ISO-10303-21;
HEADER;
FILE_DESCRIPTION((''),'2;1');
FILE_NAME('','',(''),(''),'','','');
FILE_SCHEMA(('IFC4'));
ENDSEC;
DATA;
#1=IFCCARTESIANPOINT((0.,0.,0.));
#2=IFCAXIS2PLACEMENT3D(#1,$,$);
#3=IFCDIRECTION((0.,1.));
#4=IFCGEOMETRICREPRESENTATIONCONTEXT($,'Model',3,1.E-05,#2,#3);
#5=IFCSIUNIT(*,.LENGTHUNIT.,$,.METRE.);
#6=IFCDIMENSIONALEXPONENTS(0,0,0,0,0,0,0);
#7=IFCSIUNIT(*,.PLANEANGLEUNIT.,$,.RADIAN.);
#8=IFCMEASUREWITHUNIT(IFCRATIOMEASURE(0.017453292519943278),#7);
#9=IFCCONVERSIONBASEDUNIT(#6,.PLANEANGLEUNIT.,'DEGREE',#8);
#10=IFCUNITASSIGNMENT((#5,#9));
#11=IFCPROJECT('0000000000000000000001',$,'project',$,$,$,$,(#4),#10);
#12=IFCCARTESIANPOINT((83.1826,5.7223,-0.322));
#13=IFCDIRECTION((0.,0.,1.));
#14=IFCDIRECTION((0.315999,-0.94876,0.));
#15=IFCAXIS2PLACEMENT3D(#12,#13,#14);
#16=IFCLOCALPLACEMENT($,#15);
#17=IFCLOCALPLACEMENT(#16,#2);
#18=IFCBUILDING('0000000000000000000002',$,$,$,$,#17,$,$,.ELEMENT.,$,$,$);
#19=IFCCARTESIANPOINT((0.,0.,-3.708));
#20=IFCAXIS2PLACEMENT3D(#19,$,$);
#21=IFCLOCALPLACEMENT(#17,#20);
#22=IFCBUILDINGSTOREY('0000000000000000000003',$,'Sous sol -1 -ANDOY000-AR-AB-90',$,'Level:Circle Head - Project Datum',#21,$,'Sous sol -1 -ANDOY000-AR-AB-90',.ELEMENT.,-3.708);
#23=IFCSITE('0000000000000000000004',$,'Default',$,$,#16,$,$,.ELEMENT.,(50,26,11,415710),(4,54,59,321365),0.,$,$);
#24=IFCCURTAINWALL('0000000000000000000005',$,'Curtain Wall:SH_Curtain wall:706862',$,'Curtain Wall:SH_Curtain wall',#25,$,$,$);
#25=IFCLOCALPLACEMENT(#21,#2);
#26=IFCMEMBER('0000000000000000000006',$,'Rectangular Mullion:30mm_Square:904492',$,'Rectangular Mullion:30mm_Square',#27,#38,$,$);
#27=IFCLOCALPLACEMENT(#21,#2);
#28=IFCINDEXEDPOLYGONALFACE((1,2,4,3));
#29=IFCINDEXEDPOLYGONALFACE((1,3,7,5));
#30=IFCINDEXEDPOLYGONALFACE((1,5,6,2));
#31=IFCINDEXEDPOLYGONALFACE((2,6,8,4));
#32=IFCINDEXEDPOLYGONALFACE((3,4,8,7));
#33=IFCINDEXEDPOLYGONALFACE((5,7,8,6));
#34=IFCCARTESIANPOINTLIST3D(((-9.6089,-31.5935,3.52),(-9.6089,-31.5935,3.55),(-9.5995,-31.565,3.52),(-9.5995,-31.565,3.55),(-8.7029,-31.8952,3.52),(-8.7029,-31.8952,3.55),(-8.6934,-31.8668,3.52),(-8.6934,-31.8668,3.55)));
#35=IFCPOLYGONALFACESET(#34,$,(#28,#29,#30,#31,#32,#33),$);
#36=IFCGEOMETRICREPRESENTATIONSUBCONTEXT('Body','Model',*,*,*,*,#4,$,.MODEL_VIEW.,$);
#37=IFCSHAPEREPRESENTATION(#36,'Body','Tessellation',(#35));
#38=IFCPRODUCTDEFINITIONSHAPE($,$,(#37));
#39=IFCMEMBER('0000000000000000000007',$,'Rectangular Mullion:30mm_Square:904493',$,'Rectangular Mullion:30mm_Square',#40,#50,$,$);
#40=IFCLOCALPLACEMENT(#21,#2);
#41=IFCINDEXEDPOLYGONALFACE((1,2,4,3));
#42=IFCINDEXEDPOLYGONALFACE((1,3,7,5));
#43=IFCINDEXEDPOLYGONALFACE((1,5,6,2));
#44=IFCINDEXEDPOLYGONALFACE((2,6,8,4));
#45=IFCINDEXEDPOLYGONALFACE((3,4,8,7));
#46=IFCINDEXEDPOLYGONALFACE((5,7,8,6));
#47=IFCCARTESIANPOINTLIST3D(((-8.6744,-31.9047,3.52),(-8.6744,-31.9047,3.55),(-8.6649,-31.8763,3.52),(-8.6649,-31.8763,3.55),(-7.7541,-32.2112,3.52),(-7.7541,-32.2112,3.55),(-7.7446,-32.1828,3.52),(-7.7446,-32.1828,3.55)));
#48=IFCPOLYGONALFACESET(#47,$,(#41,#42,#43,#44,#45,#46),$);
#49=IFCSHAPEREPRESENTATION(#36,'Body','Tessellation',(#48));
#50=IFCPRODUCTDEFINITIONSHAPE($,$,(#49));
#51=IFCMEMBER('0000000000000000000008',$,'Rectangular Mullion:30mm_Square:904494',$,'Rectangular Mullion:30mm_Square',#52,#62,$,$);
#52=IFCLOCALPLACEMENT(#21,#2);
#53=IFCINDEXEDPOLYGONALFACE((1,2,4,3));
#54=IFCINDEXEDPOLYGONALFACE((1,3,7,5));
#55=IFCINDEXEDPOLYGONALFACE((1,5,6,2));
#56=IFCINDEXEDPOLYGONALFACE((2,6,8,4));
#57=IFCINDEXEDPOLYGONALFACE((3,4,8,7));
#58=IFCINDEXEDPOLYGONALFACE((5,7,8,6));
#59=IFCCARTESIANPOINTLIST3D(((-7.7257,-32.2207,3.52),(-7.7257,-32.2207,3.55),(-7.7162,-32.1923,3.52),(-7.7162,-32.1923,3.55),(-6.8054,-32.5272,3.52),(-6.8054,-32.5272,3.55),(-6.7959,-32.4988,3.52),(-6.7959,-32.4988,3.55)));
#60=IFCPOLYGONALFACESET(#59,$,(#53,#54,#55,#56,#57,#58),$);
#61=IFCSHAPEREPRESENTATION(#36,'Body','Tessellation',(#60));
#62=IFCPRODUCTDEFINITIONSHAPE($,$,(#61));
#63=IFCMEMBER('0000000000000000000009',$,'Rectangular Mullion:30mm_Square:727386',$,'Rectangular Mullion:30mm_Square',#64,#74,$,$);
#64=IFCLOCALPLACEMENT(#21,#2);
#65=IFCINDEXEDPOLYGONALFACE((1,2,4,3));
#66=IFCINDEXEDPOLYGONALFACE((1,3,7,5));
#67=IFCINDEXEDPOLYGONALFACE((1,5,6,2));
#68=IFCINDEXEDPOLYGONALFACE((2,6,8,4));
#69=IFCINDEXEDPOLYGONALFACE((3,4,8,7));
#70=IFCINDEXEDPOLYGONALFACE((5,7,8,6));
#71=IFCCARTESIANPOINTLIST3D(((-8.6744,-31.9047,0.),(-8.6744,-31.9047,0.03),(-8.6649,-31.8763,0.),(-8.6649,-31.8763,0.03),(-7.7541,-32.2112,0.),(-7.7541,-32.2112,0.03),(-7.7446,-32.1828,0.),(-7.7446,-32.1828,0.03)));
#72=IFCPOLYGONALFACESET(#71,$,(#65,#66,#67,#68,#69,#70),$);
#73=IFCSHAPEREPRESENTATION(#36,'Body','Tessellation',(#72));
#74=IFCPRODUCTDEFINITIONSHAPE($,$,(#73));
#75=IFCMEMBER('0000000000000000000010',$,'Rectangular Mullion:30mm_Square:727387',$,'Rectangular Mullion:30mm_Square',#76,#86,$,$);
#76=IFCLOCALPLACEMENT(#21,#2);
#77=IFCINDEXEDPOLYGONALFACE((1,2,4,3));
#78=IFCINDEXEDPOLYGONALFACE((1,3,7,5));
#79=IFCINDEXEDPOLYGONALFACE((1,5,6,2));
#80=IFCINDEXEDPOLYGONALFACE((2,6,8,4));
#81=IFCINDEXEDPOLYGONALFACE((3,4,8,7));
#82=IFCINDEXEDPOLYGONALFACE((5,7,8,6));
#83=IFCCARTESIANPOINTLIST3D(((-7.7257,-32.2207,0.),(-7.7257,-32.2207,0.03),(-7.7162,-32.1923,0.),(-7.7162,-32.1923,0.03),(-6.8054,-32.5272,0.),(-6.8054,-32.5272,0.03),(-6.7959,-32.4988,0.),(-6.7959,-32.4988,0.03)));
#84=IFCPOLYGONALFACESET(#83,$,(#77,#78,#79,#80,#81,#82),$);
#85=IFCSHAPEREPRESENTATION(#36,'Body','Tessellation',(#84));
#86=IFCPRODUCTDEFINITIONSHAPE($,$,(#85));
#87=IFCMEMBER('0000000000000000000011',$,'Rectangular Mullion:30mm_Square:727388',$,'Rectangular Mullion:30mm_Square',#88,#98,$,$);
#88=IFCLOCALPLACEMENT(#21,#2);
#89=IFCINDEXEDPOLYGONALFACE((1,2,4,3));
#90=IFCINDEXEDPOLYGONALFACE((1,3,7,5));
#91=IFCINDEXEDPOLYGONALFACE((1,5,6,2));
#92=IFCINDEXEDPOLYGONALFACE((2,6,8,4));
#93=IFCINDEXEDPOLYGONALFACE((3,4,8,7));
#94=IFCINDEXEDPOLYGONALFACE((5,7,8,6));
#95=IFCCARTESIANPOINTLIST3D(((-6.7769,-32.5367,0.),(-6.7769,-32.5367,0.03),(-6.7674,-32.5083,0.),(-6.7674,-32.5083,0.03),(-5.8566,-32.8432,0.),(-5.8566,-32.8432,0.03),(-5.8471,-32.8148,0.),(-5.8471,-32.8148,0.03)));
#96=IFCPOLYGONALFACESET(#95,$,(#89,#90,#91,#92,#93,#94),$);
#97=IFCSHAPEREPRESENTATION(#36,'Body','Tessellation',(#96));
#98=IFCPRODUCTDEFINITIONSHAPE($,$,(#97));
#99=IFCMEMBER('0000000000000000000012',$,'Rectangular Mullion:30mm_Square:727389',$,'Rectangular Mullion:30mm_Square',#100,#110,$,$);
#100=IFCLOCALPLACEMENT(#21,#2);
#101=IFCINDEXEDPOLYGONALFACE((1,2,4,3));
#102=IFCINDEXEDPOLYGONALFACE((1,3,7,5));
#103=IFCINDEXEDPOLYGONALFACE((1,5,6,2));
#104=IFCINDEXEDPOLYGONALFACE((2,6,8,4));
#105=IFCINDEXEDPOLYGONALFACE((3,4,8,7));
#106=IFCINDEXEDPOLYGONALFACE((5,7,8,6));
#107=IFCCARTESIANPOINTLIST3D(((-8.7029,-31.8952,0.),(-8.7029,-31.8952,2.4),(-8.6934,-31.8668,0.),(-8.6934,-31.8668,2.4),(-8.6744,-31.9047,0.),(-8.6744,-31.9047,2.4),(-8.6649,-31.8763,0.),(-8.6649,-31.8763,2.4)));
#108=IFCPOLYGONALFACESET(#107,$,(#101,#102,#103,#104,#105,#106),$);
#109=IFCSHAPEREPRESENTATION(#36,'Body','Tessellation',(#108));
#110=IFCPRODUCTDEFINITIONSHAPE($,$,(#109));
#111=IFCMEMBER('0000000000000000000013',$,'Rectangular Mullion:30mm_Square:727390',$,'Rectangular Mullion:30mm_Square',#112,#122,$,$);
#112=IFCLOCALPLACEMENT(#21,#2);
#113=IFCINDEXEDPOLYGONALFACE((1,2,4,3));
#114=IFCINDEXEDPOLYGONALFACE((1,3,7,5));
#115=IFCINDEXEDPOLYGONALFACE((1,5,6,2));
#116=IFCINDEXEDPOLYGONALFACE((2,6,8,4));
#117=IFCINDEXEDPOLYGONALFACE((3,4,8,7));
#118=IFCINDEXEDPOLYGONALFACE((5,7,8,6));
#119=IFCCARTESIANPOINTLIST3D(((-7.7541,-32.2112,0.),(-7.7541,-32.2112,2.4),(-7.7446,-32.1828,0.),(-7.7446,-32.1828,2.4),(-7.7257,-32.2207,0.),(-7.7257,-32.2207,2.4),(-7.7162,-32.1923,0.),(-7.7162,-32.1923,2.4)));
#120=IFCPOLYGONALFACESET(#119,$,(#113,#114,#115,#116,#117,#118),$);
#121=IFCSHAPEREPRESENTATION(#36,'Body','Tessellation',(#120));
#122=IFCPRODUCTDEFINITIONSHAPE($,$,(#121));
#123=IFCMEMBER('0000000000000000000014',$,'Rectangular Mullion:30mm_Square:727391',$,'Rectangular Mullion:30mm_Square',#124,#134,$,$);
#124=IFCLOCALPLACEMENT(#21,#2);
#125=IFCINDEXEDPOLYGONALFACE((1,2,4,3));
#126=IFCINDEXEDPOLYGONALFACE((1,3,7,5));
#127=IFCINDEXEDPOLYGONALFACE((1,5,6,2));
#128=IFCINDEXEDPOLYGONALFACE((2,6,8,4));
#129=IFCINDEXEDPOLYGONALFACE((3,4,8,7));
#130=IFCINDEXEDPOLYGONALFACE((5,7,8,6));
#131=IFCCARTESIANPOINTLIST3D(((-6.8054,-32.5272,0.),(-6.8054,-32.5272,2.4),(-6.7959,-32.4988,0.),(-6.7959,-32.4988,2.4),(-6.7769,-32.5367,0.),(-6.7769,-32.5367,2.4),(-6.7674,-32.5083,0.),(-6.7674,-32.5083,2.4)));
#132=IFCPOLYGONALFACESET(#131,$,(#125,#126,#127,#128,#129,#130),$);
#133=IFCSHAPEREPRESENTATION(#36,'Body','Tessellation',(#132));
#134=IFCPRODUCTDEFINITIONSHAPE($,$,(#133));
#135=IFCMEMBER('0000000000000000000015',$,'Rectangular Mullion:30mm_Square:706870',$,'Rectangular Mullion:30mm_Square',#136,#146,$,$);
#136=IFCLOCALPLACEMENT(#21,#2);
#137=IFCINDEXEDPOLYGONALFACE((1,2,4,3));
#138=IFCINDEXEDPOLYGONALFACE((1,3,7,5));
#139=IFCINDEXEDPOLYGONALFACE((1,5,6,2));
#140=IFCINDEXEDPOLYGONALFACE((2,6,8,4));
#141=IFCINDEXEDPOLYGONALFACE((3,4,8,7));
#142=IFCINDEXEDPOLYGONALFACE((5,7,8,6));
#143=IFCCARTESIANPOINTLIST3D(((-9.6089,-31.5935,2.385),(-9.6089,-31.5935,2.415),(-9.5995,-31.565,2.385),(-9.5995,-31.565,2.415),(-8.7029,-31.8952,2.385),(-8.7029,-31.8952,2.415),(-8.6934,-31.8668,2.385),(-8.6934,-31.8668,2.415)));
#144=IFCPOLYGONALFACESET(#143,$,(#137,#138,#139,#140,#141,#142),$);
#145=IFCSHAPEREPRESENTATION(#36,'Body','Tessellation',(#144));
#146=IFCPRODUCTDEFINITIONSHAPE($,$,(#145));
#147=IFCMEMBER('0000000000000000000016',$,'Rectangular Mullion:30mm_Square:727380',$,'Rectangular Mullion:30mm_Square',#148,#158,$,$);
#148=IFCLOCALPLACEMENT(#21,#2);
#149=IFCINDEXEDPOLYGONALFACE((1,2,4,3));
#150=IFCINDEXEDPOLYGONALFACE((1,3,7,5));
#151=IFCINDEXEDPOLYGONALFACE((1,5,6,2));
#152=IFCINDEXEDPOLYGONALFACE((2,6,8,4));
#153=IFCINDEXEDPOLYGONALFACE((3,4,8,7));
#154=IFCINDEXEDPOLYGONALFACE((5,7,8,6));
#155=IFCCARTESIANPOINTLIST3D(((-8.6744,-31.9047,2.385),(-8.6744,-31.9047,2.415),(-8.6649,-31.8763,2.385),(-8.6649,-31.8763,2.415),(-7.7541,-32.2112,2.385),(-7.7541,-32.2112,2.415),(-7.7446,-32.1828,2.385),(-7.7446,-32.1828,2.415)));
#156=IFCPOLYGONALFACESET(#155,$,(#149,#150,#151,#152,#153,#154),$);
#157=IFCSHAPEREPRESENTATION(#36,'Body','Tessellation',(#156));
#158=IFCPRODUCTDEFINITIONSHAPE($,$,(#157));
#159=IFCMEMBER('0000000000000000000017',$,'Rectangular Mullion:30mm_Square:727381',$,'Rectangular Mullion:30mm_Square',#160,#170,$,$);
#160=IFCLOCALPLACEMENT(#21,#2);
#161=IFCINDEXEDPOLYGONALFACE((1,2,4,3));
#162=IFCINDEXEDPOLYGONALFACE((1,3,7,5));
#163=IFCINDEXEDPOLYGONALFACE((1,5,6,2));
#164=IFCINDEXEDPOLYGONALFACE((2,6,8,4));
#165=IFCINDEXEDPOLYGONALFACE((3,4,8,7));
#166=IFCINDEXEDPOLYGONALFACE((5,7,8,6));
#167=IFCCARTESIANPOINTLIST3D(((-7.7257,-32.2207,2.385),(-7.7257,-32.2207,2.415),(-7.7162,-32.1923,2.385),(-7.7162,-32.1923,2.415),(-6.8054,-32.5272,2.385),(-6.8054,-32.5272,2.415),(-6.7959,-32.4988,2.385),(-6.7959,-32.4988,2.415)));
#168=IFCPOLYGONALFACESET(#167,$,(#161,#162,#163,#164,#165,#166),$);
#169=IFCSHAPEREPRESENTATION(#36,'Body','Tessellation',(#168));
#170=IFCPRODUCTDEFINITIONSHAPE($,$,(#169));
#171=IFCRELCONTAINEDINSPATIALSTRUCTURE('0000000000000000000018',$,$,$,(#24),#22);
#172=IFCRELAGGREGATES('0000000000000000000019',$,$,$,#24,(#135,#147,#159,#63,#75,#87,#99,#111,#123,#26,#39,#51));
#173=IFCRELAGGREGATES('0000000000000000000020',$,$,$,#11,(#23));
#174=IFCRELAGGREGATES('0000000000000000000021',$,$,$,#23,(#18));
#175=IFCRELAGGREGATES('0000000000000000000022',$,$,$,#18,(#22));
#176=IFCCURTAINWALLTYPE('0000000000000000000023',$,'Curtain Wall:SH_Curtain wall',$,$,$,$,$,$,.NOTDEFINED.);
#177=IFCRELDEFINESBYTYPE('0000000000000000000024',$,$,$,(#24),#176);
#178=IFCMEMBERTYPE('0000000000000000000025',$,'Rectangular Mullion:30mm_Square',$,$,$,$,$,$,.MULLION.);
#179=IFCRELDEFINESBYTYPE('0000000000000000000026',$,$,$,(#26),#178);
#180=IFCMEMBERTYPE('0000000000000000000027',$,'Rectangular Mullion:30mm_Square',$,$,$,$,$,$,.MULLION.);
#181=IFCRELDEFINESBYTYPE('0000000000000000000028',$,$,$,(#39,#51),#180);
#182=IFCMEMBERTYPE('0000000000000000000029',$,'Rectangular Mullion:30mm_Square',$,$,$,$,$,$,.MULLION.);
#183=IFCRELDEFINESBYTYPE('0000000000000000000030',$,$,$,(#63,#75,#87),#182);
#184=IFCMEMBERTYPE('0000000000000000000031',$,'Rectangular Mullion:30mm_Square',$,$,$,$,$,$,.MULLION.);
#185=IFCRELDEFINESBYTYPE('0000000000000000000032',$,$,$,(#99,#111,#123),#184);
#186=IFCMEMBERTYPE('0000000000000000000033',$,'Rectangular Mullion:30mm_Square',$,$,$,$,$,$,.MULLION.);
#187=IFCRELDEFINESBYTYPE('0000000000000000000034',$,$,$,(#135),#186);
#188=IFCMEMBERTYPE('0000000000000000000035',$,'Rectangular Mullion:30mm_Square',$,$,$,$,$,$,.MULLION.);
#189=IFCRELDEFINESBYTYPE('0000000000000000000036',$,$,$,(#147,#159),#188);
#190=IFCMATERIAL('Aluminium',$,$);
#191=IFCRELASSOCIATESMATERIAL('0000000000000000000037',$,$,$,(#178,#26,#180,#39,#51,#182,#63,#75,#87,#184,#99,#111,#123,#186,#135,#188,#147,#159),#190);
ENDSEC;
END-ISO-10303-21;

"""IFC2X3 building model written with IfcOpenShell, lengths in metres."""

from ifc_helpers import new_model, entity, si_unit, converted_unit, direction, frame, origin, origin_2d_with_axis, place, context, subcontext, project, spatial, rectangle, extrude, source, transform, mapped, material, type_object, type_shapes, element, aggregate, save


model = new_model("IFC2X3")

# Units and contexts
model_context = context("Model", 3, precision=1e-05, world=origin(), true_north=direction((0.0, 1.0)))
body_context = subcontext(model_context, "Body", "Model", "MODEL_VIEW")
ifc_project = project(units=[si_unit("LENGTHUNIT", "METRE"), converted_unit("PLANEANGLEUNIT", "DEGREE", entity("IfcRatioMeasure", 0.017453292519943278), si_unit("PLANEANGLEUNIT", "RADIAN"), dimensions=[0, 0, 0, 0, 0, 0, 0])], contexts=[model_context])

# Site, building, storey
site_placement = place(None, frame((83.1826, 5.7223, -0.322), z_axis=(0.0, 0.0, 1.0), x_axis=(0.315999, -0.94876, 0.0)))
site = spatial("IfcSite", under=ifc_project, at=site_placement, Name="Default", CompositionType="ELEMENT", RefLatitude=(50, 26, 11, 415710), RefLongitude=(4, 54, 59, 321365), RefElevation=0.0)
building_placement = place(site_placement, origin())
building = spatial("IfcBuilding", under=site, at=building_placement, CompositionType="ELEMENT")
storey_placement = place(building_placement, frame((0.0, 0.0, -3.708)))
storey = spatial("IfcBuildingStorey", under=building, at=storey_placement, Name="Sous sol -1 -ANDOY000-AR-AB-90", ObjectType="Level:Circle Head - Project Datum", LongName="Sous sol -1 -ANDOY000-AR-AB-90", CompositionType="ELEMENT", Elevation=-3.708)

# Curtain wall, members
curtain_wall_type = type_object("IfcCurtainWallType", Name="Curtain Wall:SH_Curtain wall", PredefinedType="NOTDEFINED")
curtain_wall_1_placement = place(storey_placement, frame((0.0, 0.0, 3.708)))
curtain_wall_1 = element("IfcCurtainWall", 1, at=curtain_wall_1_placement, inside=storey, type_object=curtain_wall_type, Name="Curtain Wall:SH_Curtain wall:706862", ObjectType="Curtain Wall:SH_Curtain wall")
ifc_material_1 = material(Name="Aluminium")
member_type_1 = type_object("IfcMemberType", Name="Rectangular Mullion:30mm_Square", PredefinedType="MULLION", material=ifc_material_1)
shared_shape_1 = source(origin(), body_context, "Body", "SweptSolid", [
    extrude(rectangle(XDim=0.03, YDim=0.03, at=origin_2d_with_axis()), frame((-0.015, 0.0, -0.955), z_axis=(0.0, 0.0, 1.0), x_axis=(0.0, -1.0, 0.0)), (0.0, 0.0, 1.0), 0.955),
])
type_shapes(member_type_1, [shared_shape_1])
member_1_placement = place(curtain_wall_1_placement, frame((-8.6981, -31.881, -0.158), z_axis=(0.948759, -0.316, 0.0), x_axis=(0.0, 0.0, 1.0)))
member_1 = element("IfcMember", 2, at=member_1_placement, type_object=member_type_1, material=ifc_material_1, Name="Rectangular Mullion:30mm_Square:904492", ObjectType="Rectangular Mullion:30mm_Square", context=body_context, shape_type="MappedRepresentation", body=[
    mapped(shared_shape_1, transform((0.0, 0.0, 0.0), scale=1.0)),
])
member_type_2 = type_object("IfcMemberType", Name="Rectangular Mullion:30mm_Square", PredefinedType="MULLION", material=ifc_material_1)
shared_shape_2 = source(origin(), body_context, "Body", "SweptSolid", [
    extrude(rectangle(XDim=0.03, YDim=0.03, at=origin_2d_with_axis()), frame((-0.015, 0.0, -0.97), z_axis=(0.0, 0.0, 1.0), x_axis=(0.0, -1.0, 0.0)), (0.0, 0.0, 1.0), 0.97),
])
type_shapes(member_type_2, [shared_shape_2])
member_2_placement = place(curtain_wall_1_placement, frame((-7.7494, -32.197, -0.158), z_axis=(0.948759, -0.316, 0.0), x_axis=(0.0, 0.0, 1.0)))
member_2 = element("IfcMember", 3, at=member_2_placement, type_object=member_type_2, material=ifc_material_1, Name="Rectangular Mullion:30mm_Square:904493", ObjectType="Rectangular Mullion:30mm_Square", context=body_context, shape_type="MappedRepresentation", body=[
    mapped(shared_shape_2, transform((0.0, 0.0, 0.0), scale=1.0)),
])
member_3_placement = place(curtain_wall_1_placement, frame((-6.8006, -32.513, -0.158), z_axis=(0.948759, -0.316, 0.0), x_axis=(0.0, 0.0, 1.0)))
member_3 = element("IfcMember", 4, at=member_3_placement, type_object=member_type_2, material=ifc_material_1, Name="Rectangular Mullion:30mm_Square:904494", ObjectType="Rectangular Mullion:30mm_Square", context=body_context, shape_type="MappedRepresentation", body=[
    mapped(shared_shape_2, transform((0.0, 0.0, 0.0), scale=1.0)),
])
member_type_3 = type_object("IfcMemberType", Name="Rectangular Mullion:30mm_Square", PredefinedType="MULLION", material=ifc_material_1)
shared_shape_3 = source(origin(), body_context, "Body", "SweptSolid", [
    extrude(rectangle(XDim=0.03, YDim=0.03, at=origin_2d_with_axis()), frame((-0.015, 0.0, -0.97), z_axis=(0.0, 0.0, 1.0), x_axis=(0.0, -1.0, 0.0)), (0.0, 0.0, 1.0), 0.97),
])
type_shapes(member_type_3, [shared_shape_3])
member_4_placement = place(curtain_wall_1_placement, frame((-8.6697, -31.8905, -3.708), z_axis=(-0.948759, 0.316, 0.0), x_axis=(0.0, 0.0, -1.0)))
member_4 = element("IfcMember", 5, at=member_4_placement, type_object=member_type_3, material=ifc_material_1, Name="Rectangular Mullion:30mm_Square:727386", ObjectType="Rectangular Mullion:30mm_Square", context=body_context, shape_type="MappedRepresentation", body=[
    mapped(shared_shape_3, transform((0.0, 0.0, 0.0), scale=1.0)),
])
member_5_placement = place(curtain_wall_1_placement, frame((-7.7209, -32.2065, -3.708), z_axis=(-0.948759, 0.316, 0.0), x_axis=(0.0, 0.0, -1.0)))
member_5 = element("IfcMember", 6, at=member_5_placement, type_object=member_type_3, material=ifc_material_1, Name="Rectangular Mullion:30mm_Square:727387", ObjectType="Rectangular Mullion:30mm_Square", context=body_context, shape_type="MappedRepresentation", body=[
    mapped(shared_shape_3, transform((0.0, 0.0, 0.0), scale=1.0)),
])
member_6_placement = place(curtain_wall_1_placement, frame((-6.7722, -32.5225, -3.708), z_axis=(-0.948759, 0.316, 0.0), x_axis=(0.0, 0.0, -1.0)))
member_6 = element("IfcMember", 7, at=member_6_placement, type_object=member_type_3, material=ifc_material_1, Name="Rectangular Mullion:30mm_Square:727388", ObjectType="Rectangular Mullion:30mm_Square", context=body_context, shape_type="MappedRepresentation", body=[
    mapped(shared_shape_3, transform((0.0, 0.0, 0.0), scale=1.0)),
])
member_type_4 = type_object("IfcMemberType", Name="Rectangular Mullion:30mm_Square", PredefinedType="MULLION", material=ifc_material_1)
shared_shape_4 = source(origin(), body_context, "Body", "SweptSolid", [
    extrude(rectangle(XDim=0.03, YDim=0.03, at=origin_2d_with_axis()), frame((0.0, 0.0, -2.4), z_axis=(0.0, 0.0, 1.0), x_axis=(0.0, -1.0, 0.0)), (0.0, 0.0, 1.0), 2.4),
])
type_shapes(member_type_4, [shared_shape_4])
member_7_placement = place(curtain_wall_1_placement, frame((-8.6839, -31.8858, -3.708), z_axis=(0.0, 0.0, -1.0), x_axis=(0.948759, -0.316, 0.0)))
member_7 = element("IfcMember", 8, at=member_7_placement, type_object=member_type_4, material=ifc_material_1, Name="Rectangular Mullion:30mm_Square:727389", ObjectType="Rectangular Mullion:30mm_Square", context=body_context, shape_type="MappedRepresentation", body=[
    mapped(shared_shape_4, transform((0.0, 0.0, 0.0), scale=1.0)),
])
member_8_placement = place(curtain_wall_1_placement, frame((-7.7351, -32.2018, -3.708), z_axis=(0.0, 0.0, -1.0), x_axis=(0.948759, -0.316, 0.0)))
member_8 = element("IfcMember", 9, at=member_8_placement, type_object=member_type_4, material=ifc_material_1, Name="Rectangular Mullion:30mm_Square:727390", ObjectType="Rectangular Mullion:30mm_Square", context=body_context, shape_type="MappedRepresentation", body=[
    mapped(shared_shape_4, transform((0.0, 0.0, 0.0), scale=1.0)),
])
member_9_placement = place(curtain_wall_1_placement, frame((-6.7864, -32.5178, -3.708), z_axis=(0.0, 0.0, -1.0), x_axis=(0.948759, -0.316, 0.0)))
member_9 = element("IfcMember", 10, at=member_9_placement, type_object=member_type_4, material=ifc_material_1, Name="Rectangular Mullion:30mm_Square:727391", ObjectType="Rectangular Mullion:30mm_Square", context=body_context, shape_type="MappedRepresentation", body=[
    mapped(shared_shape_4, transform((0.0, 0.0, 0.0), scale=1.0)),
])
member_type_5 = type_object("IfcMemberType", Name="Rectangular Mullion:30mm_Square", PredefinedType="MULLION", material=ifc_material_1)
shared_shape_5 = source(origin(), body_context, "Body", "SweptSolid", [
    extrude(rectangle(XDim=0.03, YDim=0.03, at=origin_2d_with_axis()), frame((0.0, 0.0, -0.955), z_axis=(0.0, 0.0, 1.0), x_axis=(0.0, -1.0, 0.0)), (0.0, 0.0, 1.0), 0.955),
])
type_shapes(member_type_5, [shared_shape_5])
member_10_placement = place(curtain_wall_1_placement, frame((-8.6981, -31.881, -1.308), z_axis=(0.948759, -0.316, 0.0), x_axis=(0.0, 0.0, 1.0)))
member_10 = element("IfcMember", 11, at=member_10_placement, type_object=member_type_5, material=ifc_material_1, Name="Rectangular Mullion:30mm_Square:706870", ObjectType="Rectangular Mullion:30mm_Square", context=body_context, shape_type="MappedRepresentation", body=[
    mapped(shared_shape_5, transform((0.0, 0.0, 0.0), scale=1.0)),
])
member_type_6 = type_object("IfcMemberType", Name="Rectangular Mullion:30mm_Square", PredefinedType="MULLION", material=ifc_material_1)
shared_shape_6 = source(origin(), body_context, "Body", "SweptSolid", [
    extrude(rectangle(XDim=0.03, YDim=0.03, at=origin_2d_with_axis()), frame((0.0, 0.0, -0.97), z_axis=(0.0, 0.0, 1.0), x_axis=(0.0, -1.0, 0.0)), (0.0, 0.0, 1.0), 0.97),
])
type_shapes(member_type_6, [shared_shape_6])
member_11_placement = place(curtain_wall_1_placement, frame((-7.7494, -32.197, -1.308), z_axis=(0.948759, -0.316, 0.0), x_axis=(0.0, 0.0, 1.0)))
member_11 = element("IfcMember", 12, at=member_11_placement, type_object=member_type_6, material=ifc_material_1, Name="Rectangular Mullion:30mm_Square:727380", ObjectType="Rectangular Mullion:30mm_Square", context=body_context, shape_type="MappedRepresentation", body=[
    mapped(shared_shape_6, transform((0.0, 0.0, 0.0), scale=1.0)),
])
member_12_placement = place(curtain_wall_1_placement, frame((-6.8006, -32.513, -1.308), z_axis=(0.948759, -0.316, 0.0), x_axis=(0.0, 0.0, 1.0)))
member_12 = element("IfcMember", 13, at=member_12_placement, type_object=member_type_6, material=ifc_material_1, Name="Rectangular Mullion:30mm_Square:727381", ObjectType="Rectangular Mullion:30mm_Square", context=body_context, shape_type="MappedRepresentation", body=[
    mapped(shared_shape_6, transform((0.0, 0.0, 0.0), scale=1.0)),
])

aggregate(curtain_wall_1, [member_10, member_11, member_12, member_4, member_5, member_6, member_7, member_8, member_9, member_1, member_2, member_3])

save(model, "model.ifc")
